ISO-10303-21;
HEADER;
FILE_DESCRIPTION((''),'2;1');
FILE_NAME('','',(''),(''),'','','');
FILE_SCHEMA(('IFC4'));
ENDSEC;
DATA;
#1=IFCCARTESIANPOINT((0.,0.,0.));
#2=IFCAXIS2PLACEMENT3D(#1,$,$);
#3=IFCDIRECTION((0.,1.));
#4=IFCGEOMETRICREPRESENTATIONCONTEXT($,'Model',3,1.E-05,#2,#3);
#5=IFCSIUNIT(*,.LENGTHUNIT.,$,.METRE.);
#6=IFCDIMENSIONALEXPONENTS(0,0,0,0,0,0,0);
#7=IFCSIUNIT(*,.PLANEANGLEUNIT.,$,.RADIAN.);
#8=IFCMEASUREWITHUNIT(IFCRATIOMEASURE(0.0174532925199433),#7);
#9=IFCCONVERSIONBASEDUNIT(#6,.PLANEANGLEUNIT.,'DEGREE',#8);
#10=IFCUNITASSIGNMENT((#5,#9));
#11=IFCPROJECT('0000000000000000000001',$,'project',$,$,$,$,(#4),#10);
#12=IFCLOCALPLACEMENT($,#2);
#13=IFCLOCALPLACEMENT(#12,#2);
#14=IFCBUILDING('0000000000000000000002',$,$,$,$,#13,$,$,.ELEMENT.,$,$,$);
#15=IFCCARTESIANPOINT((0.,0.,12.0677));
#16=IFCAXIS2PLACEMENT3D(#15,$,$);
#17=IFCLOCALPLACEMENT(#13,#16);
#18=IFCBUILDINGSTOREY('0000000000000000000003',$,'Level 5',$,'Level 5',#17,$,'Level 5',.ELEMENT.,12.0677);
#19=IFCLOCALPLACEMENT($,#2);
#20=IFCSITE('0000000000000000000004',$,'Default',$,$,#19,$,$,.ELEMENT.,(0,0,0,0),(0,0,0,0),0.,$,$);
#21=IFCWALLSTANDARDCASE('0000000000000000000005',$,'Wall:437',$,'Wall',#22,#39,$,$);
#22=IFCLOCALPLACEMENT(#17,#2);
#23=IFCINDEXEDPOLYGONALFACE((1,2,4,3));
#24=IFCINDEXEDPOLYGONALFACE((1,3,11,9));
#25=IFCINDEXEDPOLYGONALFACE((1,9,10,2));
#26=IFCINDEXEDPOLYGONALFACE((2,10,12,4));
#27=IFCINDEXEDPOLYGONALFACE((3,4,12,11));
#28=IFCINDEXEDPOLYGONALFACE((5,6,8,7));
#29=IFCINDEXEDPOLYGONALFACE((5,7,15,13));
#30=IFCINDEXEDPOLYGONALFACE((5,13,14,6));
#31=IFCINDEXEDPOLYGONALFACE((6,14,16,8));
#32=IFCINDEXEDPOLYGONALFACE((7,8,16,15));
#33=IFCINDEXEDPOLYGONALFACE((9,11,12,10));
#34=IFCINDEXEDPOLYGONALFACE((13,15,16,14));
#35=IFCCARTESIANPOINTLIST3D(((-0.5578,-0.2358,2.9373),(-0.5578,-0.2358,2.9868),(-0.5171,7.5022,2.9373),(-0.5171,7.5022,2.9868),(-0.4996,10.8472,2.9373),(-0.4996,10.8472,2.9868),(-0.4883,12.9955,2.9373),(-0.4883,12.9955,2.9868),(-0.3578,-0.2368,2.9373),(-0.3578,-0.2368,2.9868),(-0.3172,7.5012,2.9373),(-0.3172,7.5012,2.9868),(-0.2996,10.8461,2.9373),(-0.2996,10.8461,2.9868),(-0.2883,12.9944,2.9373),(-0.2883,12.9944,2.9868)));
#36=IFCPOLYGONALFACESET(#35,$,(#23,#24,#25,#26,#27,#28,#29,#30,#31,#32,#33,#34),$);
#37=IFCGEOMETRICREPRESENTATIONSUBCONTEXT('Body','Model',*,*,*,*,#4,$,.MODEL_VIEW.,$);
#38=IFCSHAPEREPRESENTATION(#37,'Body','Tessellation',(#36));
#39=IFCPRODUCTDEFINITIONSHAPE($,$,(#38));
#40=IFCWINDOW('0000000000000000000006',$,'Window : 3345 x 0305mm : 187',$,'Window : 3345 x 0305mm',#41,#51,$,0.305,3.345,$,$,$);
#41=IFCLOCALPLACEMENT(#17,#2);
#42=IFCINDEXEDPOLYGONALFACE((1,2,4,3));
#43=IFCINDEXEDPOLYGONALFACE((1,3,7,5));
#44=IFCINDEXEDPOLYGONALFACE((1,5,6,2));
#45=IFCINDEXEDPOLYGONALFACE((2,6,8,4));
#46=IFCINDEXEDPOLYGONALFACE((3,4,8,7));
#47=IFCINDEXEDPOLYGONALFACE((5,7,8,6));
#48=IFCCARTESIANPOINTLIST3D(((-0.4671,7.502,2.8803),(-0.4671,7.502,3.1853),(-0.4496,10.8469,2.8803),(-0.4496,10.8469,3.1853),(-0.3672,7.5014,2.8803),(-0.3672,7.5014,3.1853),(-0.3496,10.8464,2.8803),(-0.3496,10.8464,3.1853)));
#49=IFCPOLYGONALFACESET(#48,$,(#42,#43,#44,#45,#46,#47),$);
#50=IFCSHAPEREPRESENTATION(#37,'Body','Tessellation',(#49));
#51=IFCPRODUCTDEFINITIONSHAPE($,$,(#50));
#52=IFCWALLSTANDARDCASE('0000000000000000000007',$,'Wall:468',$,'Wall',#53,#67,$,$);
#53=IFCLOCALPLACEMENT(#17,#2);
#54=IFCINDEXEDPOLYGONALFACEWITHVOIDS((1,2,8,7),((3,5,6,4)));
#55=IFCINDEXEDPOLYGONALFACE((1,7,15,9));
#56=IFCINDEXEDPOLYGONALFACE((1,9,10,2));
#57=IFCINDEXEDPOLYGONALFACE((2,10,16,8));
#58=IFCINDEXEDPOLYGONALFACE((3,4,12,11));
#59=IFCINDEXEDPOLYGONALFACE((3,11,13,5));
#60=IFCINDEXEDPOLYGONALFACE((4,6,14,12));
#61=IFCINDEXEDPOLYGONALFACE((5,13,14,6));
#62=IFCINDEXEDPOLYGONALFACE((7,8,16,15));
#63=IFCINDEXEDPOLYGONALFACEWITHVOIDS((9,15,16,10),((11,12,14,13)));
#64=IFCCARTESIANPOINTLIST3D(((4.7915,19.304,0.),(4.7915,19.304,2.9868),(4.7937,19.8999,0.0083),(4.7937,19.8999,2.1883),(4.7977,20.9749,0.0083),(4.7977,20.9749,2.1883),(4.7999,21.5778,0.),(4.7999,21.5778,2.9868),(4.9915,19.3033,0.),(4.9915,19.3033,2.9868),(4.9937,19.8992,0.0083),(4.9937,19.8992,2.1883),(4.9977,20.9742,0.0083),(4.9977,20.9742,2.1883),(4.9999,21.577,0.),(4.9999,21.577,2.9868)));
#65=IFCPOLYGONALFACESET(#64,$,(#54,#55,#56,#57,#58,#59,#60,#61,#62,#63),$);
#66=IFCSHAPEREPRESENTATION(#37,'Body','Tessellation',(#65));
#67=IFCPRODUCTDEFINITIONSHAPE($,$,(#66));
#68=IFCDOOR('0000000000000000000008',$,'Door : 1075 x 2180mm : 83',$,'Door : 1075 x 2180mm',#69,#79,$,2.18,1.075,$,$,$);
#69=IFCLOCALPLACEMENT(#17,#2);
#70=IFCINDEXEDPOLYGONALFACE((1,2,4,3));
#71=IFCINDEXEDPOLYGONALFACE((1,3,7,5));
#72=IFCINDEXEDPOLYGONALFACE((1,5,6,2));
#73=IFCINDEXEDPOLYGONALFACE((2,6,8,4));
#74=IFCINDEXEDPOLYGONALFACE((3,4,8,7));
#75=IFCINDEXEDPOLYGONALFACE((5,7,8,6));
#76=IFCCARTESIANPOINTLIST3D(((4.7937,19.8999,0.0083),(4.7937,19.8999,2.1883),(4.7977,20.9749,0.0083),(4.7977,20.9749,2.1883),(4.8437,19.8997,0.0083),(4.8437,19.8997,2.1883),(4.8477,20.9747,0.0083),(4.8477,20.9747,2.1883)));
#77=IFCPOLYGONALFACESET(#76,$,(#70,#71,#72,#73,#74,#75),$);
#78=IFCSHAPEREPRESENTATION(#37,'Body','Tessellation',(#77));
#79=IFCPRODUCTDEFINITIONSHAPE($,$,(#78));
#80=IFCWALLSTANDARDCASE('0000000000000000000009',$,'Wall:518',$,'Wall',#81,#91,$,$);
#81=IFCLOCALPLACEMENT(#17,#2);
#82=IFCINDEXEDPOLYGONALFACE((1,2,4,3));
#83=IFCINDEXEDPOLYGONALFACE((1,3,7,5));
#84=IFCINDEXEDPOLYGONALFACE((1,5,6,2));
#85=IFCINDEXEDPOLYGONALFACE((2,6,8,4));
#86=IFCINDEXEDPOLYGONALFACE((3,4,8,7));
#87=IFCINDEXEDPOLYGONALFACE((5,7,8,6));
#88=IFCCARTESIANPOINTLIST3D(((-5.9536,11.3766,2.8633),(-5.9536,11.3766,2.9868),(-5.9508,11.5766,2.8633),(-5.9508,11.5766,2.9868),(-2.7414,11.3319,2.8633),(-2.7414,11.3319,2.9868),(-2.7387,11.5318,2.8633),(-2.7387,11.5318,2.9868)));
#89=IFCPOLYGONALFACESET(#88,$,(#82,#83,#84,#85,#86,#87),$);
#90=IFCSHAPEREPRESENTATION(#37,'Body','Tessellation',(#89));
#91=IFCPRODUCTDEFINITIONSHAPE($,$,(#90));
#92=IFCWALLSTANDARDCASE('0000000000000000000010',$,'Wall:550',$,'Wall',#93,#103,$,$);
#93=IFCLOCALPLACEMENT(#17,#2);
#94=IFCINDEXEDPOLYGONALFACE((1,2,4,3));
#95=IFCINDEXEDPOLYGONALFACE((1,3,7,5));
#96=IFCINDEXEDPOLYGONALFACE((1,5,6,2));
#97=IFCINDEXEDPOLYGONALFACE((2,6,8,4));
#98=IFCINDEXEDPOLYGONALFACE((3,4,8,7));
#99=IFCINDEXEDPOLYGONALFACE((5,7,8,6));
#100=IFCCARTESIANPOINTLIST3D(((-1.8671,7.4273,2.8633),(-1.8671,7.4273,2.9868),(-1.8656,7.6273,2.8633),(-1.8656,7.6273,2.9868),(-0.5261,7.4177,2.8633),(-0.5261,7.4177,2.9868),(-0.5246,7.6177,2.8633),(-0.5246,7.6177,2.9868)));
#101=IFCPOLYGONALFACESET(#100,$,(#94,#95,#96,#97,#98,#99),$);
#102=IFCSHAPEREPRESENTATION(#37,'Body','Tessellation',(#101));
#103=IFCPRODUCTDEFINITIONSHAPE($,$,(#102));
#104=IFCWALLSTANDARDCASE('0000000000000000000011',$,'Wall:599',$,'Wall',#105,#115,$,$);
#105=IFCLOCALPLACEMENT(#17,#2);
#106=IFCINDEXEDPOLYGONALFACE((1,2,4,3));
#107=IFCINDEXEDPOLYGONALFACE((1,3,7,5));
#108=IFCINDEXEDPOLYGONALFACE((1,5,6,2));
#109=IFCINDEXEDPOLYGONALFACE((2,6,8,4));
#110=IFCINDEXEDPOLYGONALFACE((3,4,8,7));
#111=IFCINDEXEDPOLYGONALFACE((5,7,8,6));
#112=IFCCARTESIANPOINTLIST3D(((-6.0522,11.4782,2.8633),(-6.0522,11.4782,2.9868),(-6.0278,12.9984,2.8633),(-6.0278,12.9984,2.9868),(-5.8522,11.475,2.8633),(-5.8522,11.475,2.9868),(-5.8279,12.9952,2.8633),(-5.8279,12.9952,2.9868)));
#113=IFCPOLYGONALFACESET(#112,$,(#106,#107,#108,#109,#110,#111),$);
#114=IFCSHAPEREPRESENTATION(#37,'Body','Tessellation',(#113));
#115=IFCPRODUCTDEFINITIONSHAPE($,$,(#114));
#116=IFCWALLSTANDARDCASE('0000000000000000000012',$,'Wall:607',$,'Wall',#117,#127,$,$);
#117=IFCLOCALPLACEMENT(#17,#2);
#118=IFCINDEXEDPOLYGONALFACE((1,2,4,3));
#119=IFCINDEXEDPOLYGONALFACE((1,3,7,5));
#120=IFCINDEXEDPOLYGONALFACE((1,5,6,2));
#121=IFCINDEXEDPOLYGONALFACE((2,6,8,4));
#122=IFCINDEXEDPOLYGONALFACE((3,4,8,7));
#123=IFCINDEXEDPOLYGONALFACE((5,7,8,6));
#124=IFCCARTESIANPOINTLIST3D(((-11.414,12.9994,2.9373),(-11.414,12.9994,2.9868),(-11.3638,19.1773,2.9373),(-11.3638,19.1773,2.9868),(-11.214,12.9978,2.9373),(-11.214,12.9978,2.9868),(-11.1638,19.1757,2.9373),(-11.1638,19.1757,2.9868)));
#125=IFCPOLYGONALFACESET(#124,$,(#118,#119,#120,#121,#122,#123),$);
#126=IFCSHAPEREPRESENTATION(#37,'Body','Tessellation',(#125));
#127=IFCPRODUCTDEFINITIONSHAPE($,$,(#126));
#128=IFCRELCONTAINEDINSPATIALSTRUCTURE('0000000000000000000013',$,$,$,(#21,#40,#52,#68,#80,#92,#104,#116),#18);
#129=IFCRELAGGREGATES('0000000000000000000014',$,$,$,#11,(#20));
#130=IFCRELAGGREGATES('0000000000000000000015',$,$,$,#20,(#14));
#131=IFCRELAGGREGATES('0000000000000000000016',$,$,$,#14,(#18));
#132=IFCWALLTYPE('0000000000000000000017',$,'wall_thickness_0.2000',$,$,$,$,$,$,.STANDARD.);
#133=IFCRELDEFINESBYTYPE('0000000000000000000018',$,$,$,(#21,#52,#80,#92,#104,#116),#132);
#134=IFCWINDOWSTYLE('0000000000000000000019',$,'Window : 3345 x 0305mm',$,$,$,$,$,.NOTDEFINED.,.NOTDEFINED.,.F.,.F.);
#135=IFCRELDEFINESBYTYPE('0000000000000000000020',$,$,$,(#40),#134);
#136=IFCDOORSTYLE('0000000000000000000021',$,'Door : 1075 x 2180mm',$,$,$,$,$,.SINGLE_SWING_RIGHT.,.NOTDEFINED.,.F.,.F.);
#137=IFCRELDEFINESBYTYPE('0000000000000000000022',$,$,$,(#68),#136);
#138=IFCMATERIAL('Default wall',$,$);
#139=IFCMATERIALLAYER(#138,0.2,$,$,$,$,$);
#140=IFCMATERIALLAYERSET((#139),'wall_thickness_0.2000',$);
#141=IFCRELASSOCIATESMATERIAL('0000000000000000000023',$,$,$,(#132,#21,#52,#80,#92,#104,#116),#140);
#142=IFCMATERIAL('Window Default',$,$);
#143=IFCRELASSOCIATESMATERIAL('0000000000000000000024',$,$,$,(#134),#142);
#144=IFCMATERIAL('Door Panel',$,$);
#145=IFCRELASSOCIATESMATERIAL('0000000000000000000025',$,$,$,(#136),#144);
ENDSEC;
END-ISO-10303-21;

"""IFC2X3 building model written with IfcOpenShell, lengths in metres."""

from ifc_helpers import new_model, entity, si_unit, converted_unit, direction, frame, frame_2d, origin, origin_2d_with_axis, place, context, subcontext, project, spatial, polyline, rectangle, outline, extrude, source, transform, mapped, material, layer, layer_set, layer_usage, type_object, type_shapes, element, fill, save


model = new_model("IFC2X3")

# Units and contexts
model_context = context("Model", 3, precision=1e-05, world=origin(), true_north=direction((0.0, 1.0)))
body_context = subcontext(model_context, "Body", "Model", "MODEL_VIEW")
ifc_project = project(units=[si_unit("LENGTHUNIT", "METRE"), converted_unit("PLANEANGLEUNIT", "DEGREE", entity("IfcRatioMeasure", 0.0174532925199433), si_unit("PLANEANGLEUNIT", "RADIAN"), dimensions=[0, 0, 0, 0, 0, 0, 0])], contexts=[model_context])

# Site, building, storey
site_placement = place(None, origin())
site = spatial("IfcSite", under=ifc_project, at=site_placement, Name="Default", CompositionType="ELEMENT", RefLatitude=(0, 0, 0, 0), RefLongitude=(0, 0, 0, 0), RefElevation=0.0)
placement_1 = place(None, origin())
building_placement = place(placement_1, origin())
building = spatial("IfcBuilding", under=site, at=building_placement, CompositionType="ELEMENT")
storey_placement = place(building_placement, frame((0.0, 0.0, 12.0677)))
storey = spatial("IfcBuildingStorey", under=building, at=storey_placement, Name="Level 5", ObjectType="Level 5", LongName="Level 5", CompositionType="ELEMENT", Elevation=12.0677)

# Shared definitions
ifc_material_1 = material(Name="Default wall")
ifc_layer_1 = layer(ifc_material_1, 0.2)
ifc_layer_set_1 = layer_set([ifc_layer_1], Name="wall_thickness_0.2000")
ifc_layer_usage_1 = layer_usage(ifc_layer_set_1, "AXIS2", "POSITIVE", -0.1)
wall_type_1 = type_object("IfcWallType", Name="wall_thickness_0.2000", PredefinedType="STANDARD", material=ifc_layer_set_1)

# Wall, opening, window
placement_2 = place(building_placement, frame((0.0, 0.0, 15.005)))
wall_1_placement = place(placement_2, frame((-0.3883, 12.995, 0.0), z_axis=(0.0, 0.0, 1.0), x_axis=(-0.005256, -0.999986, 0.0)))
wall_1 = element("IfcWallStandardCase", 1, at=wall_1_placement, inside=storey, type_object=wall_type_1, material=ifc_layer_usage_1, Name="Wall:437", ObjectType="Wall", context=body_context, shape_type="SweptSolid", body=[
    extrude(outline(polyline([(13.2314, -0.1), (13.2314, 0.1), (0.0, 0.1), (0.0, -0.1), (13.2314, -0.1)])), origin(), (0.0, 0.0, 1.0), 0.0495),
])
opening_1_placement = place(wall_1_placement, frame((2.1484, -0.1, -0.057)))
opening_1 = element("IfcOpeningElement", 2, at=opening_1_placement, cuts=wall_1, ObjectType="Opening", context=body_context, shape_type="SweptSolid", body=[
    extrude(rectangle(XDim=3.345, YDim=0.305, at=frame_2d((0.1525, 1.6725), x_axis=(0.0, 1.0))), frame((0.0, 0.0, 0.0), z_axis=(0.0, 1.0, 0.0), x_axis=(0.0, 0.0, 1.0)), (0.0, 0.0, 1.0), 0.2),
])
ifc_material_2 = material(Name="Window Default")
window_style_1 = type_object("IfcWindowStyle", Name="Window : 3345 x 0305mm", ConstructionType="NOTDEFINED", OperationType="NOTDEFINED", ParameterTakesPrecedence=False, Sizeable=False, material=ifc_material_2)
shared_shape_1 = source(origin(), body_context, "Body", "SweptSolid", [
    extrude(rectangle(XDim=0.1, YDim=3.345, at=origin_2d_with_axis()), frame((1.6725, 0.1, 0.0), z_axis=(0.0, 0.0, 1.0), x_axis=(0.0, 1.0, 0.0)), (0.0, 0.0, 1.0), 0.305),
])
type_shapes(window_style_1, [shared_shape_1])
window_1_placement = place(opening_1_placement, origin())
window_1 = element("IfcWindow", 3, at=window_1_placement, inside=storey, type_object=window_style_1, Name="Window : 3345 x 0305mm : 187", ObjectType="Window : 3345 x 0305mm", OverallHeight=0.305, OverallWidth=3.345, context=body_context, shape_type="MappedRepresentation", body=[
    mapped(shared_shape_1, transform((0.0, 0.0, 0.0), scale=1.0)),
])
fill(opening_1, window_1)

# Wall, opening, door
wall_2_placement = place(storey_placement, frame((4.8915, 19.3036, 0.0), z_axis=(0.0, 0.0, 1.0), x_axis=(0.003664, 0.999993, 0.0)))
wall_2 = element("IfcWallStandardCase", 4, at=wall_2_placement, inside=storey, type_object=wall_type_1, material=ifc_layer_usage_1, Name="Wall:468", ObjectType="Wall", context=body_context, shape_type="SweptSolid", body=[
    extrude(outline(polyline([(2.2738, -0.1), (2.2738, 0.1), (0.0, 0.1), (0.0, -0.1), (2.2738, -0.1)])), origin(), (0.0, 0.0, 1.0), 2.9868),
])
opening_2_placement = place(wall_2_placement, frame((0.5959, -0.1, 0.0083)))
opening_2 = element("IfcOpeningElement", 5, at=opening_2_placement, cuts=wall_2, ObjectType="Opening", context=body_context, shape_type="SweptSolid", body=[
    extrude(rectangle(XDim=1.075, YDim=2.18, at=frame_2d((1.09, 0.5375), x_axis=(0.0, 1.0))), frame((0.0, 0.0, 0.0), z_axis=(0.0, 1.0, 0.0), x_axis=(0.0, 0.0, 1.0)), (0.0, 0.0, 1.0), 0.2),
])
ifc_material_3 = material(Name="Door Panel")
door_style_1 = type_object("IfcDoorStyle", Name="Door : 1075 x 2180mm", ConstructionType="NOTDEFINED", OperationType="SINGLE_SWING_RIGHT", ParameterTakesPrecedence=False, Sizeable=False, material=ifc_material_3)
shared_shape_2 = source(origin(), body_context, "Body", "SweptSolid", [
    extrude(rectangle(XDim=0.05, YDim=1.075, at=origin_2d_with_axis()), frame((0.5375, 0.175, 0.0), z_axis=(0.0, 0.0, 1.0), x_axis=(0.0, 1.0, 0.0)), (0.0, 0.0, 1.0), 2.18),
])
type_shapes(door_style_1, [shared_shape_2])
door_1_placement = place(opening_2_placement, origin())
door_1 = element("IfcDoor", 6, at=door_1_placement, inside=storey, type_object=door_style_1, Name="Door : 1075 x 2180mm : 83", ObjectType="Door : 1075 x 2180mm", OverallHeight=2.18, OverallWidth=1.075, context=body_context, shape_type="MappedRepresentation", body=[
    mapped(shared_shape_2, transform((0.0, 0.0, 0.0), scale=1.0)),
])
fill(opening_2, door_1)

# Walls
placement_3 = place(building_placement, frame((0.0, 0.0, 14.931)))
wall_3_placement = place(placement_3, frame((-5.9522, 11.4766, 0.0), z_axis=(0.0, 0.0, 1.0), x_axis=(0.999903, -0.013926, 0.0)))
element("IfcWallStandardCase", 7, at=wall_3_placement, inside=storey, type_object=wall_type_1, material=ifc_layer_usage_1, Name="Wall:518", ObjectType="Wall", context=body_context, shape_type="SweptSolid", body=[
    extrude(outline(polyline([(3.2124, -0.1), (3.2124, 0.1), (0.0, 0.1), (0.0, -0.1), (3.2124, -0.1)])), origin(), (0.0, 0.0, 1.0), 0.1235),
])
placement_4 = place(building_placement, frame((0.0, 0.0, 14.931)))
wall_4_placement = place(placement_4, frame((-1.8663, 7.5273, 0.0), z_axis=(0.0, 0.0, 1.0), x_axis=(0.999974, -0.007149, 0.0)))
element("IfcWallStandardCase", 8, at=wall_4_placement, inside=storey, type_object=wall_type_1, material=ifc_layer_usage_1, Name="Wall:550", ObjectType="Wall", context=body_context, shape_type="SweptSolid", body=[
    extrude(outline(polyline([(1.341, -0.1), (1.341, 0.1), (0.0, 0.1), (0.0, -0.1), (1.341, -0.1)])), origin(), (0.0, 0.0, 1.0), 0.1235),
])
placement_5 = place(building_placement, frame((0.0, 0.0, 14.931)))
wall_5_placement = place(placement_5, frame((-5.9279, 12.9968, 0.0), z_axis=(0.0, 0.0, 1.0), x_axis=(-0.015992, -0.999872, 0.0)))
element("IfcWallStandardCase", 9, at=wall_5_placement, inside=storey, type_object=wall_type_1, material=ifc_layer_usage_1, Name="Wall:599", ObjectType="Wall", context=body_context, shape_type="SweptSolid", body=[
    extrude(outline(polyline([(1.5204, -0.1), (1.5204, 0.1), (0.0, 0.1), (0.0, -0.1), (1.5204, -0.1)])), origin(), (0.0, 0.0, 1.0), 0.1235),
])
placement_6 = place(building_placement, frame((0.0, 0.0, 15.005)))
wall_6_placement = place(placement_6, frame((-11.2638, 19.1765, 0.0), z_axis=(0.0, 0.0, 1.0), x_axis=(-0.00812, -0.999967, 0.0)))
element("IfcWallStandardCase", 10, at=wall_6_placement, inside=storey, type_object=wall_type_1, material=ifc_layer_usage_1, Name="Wall:607", ObjectType="Wall", context=body_context, shape_type="SweptSolid", body=[
    extrude(outline(polyline([(6.1781, -0.1), (6.1781, 0.1), (0.0, 0.1), (0.0, -0.1), (6.1781, -0.1)])), origin(), (0.0, 0.0, 1.0), 0.0495),
])

save(model, "model.ifc")
